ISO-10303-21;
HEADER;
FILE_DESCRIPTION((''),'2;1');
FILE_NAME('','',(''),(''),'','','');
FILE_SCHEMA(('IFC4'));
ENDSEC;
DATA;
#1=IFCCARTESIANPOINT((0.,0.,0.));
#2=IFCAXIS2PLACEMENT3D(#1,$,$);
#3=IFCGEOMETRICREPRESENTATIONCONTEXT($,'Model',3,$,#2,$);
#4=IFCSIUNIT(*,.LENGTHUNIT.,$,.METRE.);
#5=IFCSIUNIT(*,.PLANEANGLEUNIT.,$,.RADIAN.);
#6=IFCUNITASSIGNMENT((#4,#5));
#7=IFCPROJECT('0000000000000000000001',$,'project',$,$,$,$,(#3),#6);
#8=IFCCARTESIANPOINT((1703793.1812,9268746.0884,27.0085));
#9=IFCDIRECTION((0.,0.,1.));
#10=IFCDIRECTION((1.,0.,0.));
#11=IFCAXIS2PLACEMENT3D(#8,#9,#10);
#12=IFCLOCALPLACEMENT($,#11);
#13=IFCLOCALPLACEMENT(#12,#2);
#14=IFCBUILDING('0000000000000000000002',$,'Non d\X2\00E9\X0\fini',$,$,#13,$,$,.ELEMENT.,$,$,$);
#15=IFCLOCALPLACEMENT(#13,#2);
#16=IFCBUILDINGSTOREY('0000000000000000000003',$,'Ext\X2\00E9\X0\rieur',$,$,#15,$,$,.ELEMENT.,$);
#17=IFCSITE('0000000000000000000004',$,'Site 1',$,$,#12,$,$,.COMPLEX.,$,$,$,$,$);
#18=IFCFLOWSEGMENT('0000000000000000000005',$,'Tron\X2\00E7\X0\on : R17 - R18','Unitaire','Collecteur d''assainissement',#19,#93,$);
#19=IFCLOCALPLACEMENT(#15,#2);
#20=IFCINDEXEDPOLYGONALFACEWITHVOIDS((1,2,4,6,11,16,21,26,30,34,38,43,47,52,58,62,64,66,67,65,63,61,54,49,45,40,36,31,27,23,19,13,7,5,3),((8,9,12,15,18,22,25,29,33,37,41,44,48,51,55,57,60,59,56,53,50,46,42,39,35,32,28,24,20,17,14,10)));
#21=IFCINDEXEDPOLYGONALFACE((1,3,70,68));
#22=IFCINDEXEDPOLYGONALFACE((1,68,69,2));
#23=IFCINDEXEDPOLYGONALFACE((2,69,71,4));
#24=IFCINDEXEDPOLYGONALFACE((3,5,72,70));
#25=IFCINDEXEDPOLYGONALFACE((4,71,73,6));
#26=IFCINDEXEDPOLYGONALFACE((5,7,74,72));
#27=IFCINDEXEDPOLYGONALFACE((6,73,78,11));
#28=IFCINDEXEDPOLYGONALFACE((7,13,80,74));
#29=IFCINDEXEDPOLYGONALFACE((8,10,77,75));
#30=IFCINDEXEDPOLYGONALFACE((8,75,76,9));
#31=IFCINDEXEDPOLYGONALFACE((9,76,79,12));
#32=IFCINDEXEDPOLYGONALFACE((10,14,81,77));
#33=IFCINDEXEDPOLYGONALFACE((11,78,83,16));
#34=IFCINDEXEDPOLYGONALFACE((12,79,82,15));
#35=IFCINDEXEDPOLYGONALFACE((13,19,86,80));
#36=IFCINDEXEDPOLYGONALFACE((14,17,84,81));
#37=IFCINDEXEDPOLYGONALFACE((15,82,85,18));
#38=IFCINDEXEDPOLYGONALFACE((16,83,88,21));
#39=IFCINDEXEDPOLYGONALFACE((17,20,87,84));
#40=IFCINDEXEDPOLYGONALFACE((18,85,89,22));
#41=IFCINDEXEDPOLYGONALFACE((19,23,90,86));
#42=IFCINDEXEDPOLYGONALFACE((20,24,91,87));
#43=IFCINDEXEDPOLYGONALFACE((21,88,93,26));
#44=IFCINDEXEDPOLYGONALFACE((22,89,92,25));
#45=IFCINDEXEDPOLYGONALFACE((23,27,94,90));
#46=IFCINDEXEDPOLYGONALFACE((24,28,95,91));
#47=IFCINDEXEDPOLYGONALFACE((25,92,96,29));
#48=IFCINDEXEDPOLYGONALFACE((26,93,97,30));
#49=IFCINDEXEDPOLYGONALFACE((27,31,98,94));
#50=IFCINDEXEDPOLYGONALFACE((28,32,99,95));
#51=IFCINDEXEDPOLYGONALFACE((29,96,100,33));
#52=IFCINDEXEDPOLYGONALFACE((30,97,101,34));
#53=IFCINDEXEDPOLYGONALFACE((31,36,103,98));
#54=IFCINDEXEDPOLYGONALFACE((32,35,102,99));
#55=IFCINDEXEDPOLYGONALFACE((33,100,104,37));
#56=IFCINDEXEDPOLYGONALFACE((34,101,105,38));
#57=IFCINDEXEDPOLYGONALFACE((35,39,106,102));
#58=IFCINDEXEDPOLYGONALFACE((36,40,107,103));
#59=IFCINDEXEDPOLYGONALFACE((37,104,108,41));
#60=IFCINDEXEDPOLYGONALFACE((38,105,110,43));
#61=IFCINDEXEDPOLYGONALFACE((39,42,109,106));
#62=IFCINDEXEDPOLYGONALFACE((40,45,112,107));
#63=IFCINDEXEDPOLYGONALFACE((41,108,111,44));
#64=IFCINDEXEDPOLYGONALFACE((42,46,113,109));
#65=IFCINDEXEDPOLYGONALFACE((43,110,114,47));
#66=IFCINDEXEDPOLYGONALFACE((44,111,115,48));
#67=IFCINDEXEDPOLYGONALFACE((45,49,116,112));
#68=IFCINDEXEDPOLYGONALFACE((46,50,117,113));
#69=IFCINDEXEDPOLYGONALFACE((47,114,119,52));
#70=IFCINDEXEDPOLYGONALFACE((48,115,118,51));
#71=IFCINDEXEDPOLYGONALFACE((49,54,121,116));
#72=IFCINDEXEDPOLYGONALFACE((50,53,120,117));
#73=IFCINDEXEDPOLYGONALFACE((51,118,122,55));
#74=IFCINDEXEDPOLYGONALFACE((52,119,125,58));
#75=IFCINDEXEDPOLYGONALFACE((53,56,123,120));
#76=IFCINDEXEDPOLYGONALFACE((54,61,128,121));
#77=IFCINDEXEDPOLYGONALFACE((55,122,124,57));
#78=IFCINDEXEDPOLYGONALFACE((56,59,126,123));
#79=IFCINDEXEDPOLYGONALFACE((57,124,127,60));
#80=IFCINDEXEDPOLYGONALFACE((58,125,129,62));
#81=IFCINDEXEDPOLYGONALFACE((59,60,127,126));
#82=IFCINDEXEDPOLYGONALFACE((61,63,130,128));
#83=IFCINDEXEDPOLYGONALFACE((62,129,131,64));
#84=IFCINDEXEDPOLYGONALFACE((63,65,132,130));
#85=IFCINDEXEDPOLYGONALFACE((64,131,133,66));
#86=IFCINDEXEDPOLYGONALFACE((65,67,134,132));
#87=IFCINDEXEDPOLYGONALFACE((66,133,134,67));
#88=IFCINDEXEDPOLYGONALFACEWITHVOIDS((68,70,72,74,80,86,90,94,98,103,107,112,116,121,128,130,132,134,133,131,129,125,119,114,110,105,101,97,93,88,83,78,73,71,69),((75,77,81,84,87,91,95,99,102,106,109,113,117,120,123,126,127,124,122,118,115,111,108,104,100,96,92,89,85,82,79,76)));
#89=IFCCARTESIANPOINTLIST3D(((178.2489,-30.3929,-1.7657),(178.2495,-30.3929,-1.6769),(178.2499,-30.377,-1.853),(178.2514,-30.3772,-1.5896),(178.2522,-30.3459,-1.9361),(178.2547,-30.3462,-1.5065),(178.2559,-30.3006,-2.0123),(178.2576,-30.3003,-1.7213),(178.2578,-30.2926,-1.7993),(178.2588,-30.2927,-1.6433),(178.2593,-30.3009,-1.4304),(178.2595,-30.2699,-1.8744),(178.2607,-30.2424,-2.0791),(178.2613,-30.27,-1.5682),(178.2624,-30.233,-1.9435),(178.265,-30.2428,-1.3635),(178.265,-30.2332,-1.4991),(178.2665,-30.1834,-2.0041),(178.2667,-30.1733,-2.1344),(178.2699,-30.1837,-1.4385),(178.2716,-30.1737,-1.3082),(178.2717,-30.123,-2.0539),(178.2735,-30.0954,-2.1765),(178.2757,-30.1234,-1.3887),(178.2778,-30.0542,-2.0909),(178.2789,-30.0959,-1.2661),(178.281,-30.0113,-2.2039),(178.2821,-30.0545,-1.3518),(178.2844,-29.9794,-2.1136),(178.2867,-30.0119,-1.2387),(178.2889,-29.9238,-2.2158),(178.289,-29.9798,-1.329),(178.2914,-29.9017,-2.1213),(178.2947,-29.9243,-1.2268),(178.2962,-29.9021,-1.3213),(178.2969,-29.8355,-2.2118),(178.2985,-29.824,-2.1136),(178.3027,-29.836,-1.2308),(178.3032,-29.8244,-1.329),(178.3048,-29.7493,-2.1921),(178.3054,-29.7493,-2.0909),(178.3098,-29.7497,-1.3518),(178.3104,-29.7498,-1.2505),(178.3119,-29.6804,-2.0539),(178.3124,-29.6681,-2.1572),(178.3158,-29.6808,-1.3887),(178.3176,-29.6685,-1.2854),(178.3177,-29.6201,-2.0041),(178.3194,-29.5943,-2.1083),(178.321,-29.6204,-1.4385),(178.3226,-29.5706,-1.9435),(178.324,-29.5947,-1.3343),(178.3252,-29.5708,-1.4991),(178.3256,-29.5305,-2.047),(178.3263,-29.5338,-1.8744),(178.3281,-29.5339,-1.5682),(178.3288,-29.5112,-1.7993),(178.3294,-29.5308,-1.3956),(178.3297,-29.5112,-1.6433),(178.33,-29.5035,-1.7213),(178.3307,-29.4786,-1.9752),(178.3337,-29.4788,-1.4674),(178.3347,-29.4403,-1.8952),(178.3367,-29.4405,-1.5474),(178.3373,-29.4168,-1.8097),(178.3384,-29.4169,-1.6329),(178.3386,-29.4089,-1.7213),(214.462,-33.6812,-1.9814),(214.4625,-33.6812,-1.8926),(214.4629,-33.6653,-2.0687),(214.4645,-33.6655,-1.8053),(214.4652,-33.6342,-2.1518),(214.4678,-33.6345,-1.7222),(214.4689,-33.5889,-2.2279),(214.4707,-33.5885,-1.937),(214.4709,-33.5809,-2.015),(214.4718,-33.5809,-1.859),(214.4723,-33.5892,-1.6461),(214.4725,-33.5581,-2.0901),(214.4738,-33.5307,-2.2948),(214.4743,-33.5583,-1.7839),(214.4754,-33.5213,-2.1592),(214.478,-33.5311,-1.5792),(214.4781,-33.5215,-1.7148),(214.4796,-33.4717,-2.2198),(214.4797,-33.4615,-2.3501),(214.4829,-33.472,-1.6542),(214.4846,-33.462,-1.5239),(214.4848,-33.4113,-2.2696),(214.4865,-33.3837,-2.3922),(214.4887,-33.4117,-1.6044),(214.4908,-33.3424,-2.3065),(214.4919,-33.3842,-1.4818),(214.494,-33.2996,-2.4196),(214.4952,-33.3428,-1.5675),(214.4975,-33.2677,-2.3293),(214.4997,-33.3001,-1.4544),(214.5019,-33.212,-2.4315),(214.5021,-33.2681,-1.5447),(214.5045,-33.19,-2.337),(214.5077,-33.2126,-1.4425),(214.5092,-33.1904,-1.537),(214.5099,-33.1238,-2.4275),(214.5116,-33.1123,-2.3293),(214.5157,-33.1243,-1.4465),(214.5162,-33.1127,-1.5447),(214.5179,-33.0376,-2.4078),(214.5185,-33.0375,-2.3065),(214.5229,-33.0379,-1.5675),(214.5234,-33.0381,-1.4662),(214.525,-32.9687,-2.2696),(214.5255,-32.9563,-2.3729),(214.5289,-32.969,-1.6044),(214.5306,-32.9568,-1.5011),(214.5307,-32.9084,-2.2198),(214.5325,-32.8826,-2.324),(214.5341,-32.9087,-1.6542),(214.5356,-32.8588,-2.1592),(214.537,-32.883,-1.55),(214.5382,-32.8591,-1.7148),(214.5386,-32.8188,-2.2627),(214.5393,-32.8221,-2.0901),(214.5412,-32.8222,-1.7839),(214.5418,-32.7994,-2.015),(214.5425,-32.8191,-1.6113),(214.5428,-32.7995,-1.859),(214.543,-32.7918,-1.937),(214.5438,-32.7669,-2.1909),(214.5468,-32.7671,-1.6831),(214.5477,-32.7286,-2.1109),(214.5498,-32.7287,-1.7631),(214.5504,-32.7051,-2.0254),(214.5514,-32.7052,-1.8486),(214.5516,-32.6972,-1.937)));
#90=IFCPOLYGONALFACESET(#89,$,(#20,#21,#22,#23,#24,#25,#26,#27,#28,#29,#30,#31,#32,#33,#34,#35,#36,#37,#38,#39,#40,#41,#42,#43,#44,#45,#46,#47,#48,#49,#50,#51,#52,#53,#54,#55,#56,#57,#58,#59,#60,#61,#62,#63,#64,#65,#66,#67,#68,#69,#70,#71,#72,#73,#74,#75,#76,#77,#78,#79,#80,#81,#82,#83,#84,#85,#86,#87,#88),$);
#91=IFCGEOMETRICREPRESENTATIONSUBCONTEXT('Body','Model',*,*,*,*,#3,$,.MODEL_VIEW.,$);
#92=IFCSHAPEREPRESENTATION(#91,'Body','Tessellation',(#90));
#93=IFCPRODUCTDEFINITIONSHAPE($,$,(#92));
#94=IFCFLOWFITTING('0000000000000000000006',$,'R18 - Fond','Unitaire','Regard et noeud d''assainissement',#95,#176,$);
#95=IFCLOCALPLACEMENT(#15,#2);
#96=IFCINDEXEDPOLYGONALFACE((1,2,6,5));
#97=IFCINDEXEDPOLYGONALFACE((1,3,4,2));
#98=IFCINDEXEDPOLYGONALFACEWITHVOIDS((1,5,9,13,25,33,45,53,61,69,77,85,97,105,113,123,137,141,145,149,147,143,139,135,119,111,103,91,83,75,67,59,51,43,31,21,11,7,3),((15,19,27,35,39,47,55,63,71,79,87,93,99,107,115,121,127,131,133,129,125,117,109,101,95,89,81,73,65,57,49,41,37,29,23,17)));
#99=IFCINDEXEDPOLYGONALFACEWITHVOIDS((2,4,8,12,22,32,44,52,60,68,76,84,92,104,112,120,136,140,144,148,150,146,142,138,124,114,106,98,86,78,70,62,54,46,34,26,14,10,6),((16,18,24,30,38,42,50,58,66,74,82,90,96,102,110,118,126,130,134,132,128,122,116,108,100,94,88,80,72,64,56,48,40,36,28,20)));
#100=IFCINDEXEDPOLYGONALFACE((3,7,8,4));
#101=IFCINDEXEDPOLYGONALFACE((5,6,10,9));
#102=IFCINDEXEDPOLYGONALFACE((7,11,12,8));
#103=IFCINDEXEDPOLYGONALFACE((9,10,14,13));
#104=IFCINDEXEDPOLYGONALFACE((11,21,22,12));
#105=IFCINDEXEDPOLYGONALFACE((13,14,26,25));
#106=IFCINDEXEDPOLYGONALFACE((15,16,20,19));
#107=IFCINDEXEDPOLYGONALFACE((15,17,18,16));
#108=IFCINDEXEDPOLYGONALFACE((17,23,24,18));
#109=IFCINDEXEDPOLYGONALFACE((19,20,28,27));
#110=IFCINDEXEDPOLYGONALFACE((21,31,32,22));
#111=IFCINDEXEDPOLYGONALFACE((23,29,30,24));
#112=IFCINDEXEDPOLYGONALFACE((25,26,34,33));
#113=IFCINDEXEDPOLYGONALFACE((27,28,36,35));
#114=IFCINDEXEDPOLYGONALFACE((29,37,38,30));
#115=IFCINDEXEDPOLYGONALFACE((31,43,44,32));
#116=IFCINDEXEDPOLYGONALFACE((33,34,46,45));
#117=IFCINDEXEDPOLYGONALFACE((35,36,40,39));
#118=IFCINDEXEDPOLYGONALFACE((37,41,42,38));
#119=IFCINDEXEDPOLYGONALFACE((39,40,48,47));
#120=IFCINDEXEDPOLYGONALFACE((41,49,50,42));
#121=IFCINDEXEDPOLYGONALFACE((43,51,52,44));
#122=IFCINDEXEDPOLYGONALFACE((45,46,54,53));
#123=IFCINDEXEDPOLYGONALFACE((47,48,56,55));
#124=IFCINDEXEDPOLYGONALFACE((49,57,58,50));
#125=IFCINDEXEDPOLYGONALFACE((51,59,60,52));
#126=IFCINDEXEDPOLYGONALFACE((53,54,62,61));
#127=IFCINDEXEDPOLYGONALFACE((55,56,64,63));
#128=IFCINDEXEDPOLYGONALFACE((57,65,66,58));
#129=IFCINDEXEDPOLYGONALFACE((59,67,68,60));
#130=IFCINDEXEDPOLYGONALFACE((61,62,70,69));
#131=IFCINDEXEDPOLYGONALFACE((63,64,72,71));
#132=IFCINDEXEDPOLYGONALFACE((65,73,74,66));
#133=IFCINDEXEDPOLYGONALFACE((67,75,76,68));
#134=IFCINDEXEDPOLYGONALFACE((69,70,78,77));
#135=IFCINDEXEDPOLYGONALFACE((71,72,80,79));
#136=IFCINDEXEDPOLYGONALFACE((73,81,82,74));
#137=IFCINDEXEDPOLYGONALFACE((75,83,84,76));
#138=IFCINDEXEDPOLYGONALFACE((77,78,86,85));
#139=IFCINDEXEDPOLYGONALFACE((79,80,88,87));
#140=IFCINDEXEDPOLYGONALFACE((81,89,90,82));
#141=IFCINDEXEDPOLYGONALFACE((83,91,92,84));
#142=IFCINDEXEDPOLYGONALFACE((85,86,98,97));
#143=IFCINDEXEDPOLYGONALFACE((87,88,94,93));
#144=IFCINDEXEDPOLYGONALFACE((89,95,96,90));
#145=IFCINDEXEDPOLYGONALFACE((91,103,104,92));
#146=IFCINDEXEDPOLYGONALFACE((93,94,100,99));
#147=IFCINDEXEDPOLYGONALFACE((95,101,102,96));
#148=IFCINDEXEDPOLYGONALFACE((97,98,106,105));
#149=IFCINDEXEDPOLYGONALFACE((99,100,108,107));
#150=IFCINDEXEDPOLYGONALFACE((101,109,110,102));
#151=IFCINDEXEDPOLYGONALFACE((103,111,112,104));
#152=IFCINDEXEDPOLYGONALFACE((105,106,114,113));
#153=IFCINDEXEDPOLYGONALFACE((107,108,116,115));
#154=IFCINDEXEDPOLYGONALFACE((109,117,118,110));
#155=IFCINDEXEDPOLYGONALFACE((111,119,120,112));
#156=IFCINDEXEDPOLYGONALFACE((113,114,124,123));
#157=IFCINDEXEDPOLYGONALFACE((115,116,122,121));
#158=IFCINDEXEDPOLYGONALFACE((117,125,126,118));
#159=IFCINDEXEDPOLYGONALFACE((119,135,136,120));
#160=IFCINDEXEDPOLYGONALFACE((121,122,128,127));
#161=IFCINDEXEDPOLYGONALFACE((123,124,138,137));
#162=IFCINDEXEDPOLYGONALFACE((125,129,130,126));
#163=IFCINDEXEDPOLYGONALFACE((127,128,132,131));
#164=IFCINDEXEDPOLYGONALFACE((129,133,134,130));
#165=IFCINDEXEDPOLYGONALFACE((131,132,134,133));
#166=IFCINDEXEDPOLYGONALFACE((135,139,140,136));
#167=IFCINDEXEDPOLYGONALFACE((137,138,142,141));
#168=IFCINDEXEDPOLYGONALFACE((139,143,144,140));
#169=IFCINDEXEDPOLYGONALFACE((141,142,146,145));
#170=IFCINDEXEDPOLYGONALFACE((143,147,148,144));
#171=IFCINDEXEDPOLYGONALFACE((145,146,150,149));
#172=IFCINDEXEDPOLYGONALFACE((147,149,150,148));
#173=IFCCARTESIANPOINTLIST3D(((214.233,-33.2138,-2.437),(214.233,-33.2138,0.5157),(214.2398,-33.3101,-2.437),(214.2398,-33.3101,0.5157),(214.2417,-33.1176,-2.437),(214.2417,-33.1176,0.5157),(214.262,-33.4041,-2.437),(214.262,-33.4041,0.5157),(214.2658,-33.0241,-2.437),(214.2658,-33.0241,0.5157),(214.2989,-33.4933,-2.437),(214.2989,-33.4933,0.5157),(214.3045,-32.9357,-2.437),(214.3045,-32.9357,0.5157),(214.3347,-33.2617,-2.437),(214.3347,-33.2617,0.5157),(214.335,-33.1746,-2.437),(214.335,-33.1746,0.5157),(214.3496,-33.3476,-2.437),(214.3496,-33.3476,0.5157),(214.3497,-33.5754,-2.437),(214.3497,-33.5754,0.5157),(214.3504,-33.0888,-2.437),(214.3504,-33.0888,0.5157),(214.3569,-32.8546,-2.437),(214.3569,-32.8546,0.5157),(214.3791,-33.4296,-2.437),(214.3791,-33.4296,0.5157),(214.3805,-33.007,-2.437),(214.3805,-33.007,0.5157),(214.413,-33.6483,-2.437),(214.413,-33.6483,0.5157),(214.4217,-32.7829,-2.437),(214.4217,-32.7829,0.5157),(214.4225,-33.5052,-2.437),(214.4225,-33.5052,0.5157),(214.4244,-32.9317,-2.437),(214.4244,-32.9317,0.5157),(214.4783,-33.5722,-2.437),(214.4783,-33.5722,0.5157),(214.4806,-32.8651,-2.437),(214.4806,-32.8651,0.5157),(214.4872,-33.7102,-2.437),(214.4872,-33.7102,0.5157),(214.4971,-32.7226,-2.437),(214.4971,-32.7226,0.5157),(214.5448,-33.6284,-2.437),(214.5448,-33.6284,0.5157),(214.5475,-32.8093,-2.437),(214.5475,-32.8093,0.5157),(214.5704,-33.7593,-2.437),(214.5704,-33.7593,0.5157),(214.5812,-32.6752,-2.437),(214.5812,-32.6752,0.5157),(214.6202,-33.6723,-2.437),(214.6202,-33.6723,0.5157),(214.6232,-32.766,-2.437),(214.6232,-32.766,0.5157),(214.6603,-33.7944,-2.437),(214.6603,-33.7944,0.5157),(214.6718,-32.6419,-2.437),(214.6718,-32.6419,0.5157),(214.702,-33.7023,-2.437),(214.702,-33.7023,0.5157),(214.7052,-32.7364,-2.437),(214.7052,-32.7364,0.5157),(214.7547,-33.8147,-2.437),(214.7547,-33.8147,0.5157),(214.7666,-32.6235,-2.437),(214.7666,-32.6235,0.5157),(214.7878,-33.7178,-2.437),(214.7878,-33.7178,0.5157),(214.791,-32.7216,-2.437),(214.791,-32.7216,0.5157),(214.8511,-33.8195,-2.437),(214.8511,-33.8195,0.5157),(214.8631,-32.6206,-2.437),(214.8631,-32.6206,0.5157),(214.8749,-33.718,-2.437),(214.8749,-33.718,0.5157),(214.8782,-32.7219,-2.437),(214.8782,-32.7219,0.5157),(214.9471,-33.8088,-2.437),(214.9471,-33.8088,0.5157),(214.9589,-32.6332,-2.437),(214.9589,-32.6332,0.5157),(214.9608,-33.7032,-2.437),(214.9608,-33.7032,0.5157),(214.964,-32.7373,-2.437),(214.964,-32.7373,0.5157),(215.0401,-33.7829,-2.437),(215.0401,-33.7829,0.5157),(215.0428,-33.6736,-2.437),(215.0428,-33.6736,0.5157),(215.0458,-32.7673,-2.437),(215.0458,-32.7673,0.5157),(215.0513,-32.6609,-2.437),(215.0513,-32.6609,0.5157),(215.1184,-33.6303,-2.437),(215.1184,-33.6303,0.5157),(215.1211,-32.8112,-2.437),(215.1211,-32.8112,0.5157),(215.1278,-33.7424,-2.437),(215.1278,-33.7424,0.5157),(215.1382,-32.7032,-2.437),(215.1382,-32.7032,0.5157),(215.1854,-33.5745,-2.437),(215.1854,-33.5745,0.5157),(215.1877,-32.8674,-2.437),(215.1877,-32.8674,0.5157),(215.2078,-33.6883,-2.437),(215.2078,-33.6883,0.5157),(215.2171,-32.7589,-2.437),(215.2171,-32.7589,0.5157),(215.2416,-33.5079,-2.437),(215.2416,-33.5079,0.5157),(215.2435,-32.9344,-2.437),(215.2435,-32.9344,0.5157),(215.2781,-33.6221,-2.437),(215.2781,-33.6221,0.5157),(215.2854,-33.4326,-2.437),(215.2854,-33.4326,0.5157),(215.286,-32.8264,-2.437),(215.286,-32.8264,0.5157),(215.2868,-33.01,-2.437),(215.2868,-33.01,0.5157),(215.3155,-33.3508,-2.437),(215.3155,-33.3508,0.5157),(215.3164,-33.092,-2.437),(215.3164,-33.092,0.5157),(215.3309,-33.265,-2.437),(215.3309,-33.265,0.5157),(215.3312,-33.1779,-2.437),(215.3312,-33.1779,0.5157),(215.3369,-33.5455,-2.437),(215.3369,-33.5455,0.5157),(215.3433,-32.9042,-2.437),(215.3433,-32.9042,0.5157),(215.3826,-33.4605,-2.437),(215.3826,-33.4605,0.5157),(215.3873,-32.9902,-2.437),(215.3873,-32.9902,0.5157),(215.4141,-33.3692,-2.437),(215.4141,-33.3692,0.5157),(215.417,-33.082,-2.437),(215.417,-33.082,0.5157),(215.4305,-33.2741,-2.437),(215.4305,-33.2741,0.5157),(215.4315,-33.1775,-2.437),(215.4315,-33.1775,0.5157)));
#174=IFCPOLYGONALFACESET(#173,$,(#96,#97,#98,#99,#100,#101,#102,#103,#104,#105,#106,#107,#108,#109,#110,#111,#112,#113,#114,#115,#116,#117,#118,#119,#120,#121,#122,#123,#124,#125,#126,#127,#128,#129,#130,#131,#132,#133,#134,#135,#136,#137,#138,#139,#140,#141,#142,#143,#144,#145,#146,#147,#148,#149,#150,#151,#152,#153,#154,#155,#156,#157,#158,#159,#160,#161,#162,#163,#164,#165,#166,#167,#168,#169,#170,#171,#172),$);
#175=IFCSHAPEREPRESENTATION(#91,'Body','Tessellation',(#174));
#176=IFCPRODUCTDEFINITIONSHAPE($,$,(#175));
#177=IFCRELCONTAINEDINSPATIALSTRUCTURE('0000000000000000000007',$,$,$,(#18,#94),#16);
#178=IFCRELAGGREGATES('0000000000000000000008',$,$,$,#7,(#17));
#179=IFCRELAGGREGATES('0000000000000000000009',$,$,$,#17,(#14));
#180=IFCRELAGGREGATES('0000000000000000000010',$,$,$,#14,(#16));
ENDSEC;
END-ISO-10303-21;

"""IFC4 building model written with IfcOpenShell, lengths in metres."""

from ifc_helpers import new_model, si_unit, frame, origin, origin_2d, place, context, subcontext, project, spatial, hollow_circle, extrude, element, save


model = new_model("IFC4")

# Units and contexts
model_context = context("Model", 3, world=origin())
body_context = subcontext(model_context, "Body", "Model", "MODEL_VIEW")
ifc_project = project(units=[si_unit("LENGTHUNIT", "METRE"), si_unit("PLANEANGLEUNIT", "RADIAN")], contexts=[model_context])

# Site, building, storey
site_placement = place(None, frame((1703793.1812, 9268746.0884, 27.0085), z_axis=(0.0, 0.0, 1.0), x_axis=(1.0, 0.0, 0.0)))
site = spatial("IfcSite", under=ifc_project, at=site_placement, Name="Site 1", CompositionType="COMPLEX")
building_placement = place(site_placement, origin())
building = spatial("IfcBuilding", under=site, at=building_placement, Name="Non défini", CompositionType="ELEMENT")
storey_placement = place(building_placement, origin())
storey = spatial("IfcBuildingStorey", under=building, at=storey_placement, Name="Extérieur", CompositionType="ELEMENT")

# Flow segment
flow_segment_1_placement = place(storey_placement, origin())
element("IfcFlowSegment", 1, at=flow_segment_1_placement, inside=storey, Name="Tronçon : R17 - R18", Description="Unitaire", ObjectType="Collecteur d'assainissement", context=body_context, shape_type="SweptSolid", body=[
    extrude(hollow_circle(Radius=0.495, WallThickness=0.095, at=origin_2d()), frame((178.2938, -29.9019, -1.7213), z_axis=(0.995885, -0.09043, -0.005932), x_axis=(0.090432, 0.995903, 0.0)), (0.0, 0.0, 1.0), 36.3627),
])

# Flow fitting
flow_fitting_1_placement = place(storey_placement, origin())
element("IfcFlowFitting", 2, at=flow_fitting_1_placement, inside=storey, Name="R18 - Fond", Description="Unitaire", ObjectType="Regard et noeud d'assainissement", context=body_context, shape_type="SweptSolid", body=[
    extrude(hollow_circle(Radius=0.6, WallThickness=0.1, at=origin_2d()), frame((214.833, -33.2198, -2.437), z_axis=(0.0, 0.0, 1.0), x_axis=(0.995903, -0.090432, 0.0)), (0.0, 0.0, 1.0), 2.9527),
])

save(model, "model.ifc")
